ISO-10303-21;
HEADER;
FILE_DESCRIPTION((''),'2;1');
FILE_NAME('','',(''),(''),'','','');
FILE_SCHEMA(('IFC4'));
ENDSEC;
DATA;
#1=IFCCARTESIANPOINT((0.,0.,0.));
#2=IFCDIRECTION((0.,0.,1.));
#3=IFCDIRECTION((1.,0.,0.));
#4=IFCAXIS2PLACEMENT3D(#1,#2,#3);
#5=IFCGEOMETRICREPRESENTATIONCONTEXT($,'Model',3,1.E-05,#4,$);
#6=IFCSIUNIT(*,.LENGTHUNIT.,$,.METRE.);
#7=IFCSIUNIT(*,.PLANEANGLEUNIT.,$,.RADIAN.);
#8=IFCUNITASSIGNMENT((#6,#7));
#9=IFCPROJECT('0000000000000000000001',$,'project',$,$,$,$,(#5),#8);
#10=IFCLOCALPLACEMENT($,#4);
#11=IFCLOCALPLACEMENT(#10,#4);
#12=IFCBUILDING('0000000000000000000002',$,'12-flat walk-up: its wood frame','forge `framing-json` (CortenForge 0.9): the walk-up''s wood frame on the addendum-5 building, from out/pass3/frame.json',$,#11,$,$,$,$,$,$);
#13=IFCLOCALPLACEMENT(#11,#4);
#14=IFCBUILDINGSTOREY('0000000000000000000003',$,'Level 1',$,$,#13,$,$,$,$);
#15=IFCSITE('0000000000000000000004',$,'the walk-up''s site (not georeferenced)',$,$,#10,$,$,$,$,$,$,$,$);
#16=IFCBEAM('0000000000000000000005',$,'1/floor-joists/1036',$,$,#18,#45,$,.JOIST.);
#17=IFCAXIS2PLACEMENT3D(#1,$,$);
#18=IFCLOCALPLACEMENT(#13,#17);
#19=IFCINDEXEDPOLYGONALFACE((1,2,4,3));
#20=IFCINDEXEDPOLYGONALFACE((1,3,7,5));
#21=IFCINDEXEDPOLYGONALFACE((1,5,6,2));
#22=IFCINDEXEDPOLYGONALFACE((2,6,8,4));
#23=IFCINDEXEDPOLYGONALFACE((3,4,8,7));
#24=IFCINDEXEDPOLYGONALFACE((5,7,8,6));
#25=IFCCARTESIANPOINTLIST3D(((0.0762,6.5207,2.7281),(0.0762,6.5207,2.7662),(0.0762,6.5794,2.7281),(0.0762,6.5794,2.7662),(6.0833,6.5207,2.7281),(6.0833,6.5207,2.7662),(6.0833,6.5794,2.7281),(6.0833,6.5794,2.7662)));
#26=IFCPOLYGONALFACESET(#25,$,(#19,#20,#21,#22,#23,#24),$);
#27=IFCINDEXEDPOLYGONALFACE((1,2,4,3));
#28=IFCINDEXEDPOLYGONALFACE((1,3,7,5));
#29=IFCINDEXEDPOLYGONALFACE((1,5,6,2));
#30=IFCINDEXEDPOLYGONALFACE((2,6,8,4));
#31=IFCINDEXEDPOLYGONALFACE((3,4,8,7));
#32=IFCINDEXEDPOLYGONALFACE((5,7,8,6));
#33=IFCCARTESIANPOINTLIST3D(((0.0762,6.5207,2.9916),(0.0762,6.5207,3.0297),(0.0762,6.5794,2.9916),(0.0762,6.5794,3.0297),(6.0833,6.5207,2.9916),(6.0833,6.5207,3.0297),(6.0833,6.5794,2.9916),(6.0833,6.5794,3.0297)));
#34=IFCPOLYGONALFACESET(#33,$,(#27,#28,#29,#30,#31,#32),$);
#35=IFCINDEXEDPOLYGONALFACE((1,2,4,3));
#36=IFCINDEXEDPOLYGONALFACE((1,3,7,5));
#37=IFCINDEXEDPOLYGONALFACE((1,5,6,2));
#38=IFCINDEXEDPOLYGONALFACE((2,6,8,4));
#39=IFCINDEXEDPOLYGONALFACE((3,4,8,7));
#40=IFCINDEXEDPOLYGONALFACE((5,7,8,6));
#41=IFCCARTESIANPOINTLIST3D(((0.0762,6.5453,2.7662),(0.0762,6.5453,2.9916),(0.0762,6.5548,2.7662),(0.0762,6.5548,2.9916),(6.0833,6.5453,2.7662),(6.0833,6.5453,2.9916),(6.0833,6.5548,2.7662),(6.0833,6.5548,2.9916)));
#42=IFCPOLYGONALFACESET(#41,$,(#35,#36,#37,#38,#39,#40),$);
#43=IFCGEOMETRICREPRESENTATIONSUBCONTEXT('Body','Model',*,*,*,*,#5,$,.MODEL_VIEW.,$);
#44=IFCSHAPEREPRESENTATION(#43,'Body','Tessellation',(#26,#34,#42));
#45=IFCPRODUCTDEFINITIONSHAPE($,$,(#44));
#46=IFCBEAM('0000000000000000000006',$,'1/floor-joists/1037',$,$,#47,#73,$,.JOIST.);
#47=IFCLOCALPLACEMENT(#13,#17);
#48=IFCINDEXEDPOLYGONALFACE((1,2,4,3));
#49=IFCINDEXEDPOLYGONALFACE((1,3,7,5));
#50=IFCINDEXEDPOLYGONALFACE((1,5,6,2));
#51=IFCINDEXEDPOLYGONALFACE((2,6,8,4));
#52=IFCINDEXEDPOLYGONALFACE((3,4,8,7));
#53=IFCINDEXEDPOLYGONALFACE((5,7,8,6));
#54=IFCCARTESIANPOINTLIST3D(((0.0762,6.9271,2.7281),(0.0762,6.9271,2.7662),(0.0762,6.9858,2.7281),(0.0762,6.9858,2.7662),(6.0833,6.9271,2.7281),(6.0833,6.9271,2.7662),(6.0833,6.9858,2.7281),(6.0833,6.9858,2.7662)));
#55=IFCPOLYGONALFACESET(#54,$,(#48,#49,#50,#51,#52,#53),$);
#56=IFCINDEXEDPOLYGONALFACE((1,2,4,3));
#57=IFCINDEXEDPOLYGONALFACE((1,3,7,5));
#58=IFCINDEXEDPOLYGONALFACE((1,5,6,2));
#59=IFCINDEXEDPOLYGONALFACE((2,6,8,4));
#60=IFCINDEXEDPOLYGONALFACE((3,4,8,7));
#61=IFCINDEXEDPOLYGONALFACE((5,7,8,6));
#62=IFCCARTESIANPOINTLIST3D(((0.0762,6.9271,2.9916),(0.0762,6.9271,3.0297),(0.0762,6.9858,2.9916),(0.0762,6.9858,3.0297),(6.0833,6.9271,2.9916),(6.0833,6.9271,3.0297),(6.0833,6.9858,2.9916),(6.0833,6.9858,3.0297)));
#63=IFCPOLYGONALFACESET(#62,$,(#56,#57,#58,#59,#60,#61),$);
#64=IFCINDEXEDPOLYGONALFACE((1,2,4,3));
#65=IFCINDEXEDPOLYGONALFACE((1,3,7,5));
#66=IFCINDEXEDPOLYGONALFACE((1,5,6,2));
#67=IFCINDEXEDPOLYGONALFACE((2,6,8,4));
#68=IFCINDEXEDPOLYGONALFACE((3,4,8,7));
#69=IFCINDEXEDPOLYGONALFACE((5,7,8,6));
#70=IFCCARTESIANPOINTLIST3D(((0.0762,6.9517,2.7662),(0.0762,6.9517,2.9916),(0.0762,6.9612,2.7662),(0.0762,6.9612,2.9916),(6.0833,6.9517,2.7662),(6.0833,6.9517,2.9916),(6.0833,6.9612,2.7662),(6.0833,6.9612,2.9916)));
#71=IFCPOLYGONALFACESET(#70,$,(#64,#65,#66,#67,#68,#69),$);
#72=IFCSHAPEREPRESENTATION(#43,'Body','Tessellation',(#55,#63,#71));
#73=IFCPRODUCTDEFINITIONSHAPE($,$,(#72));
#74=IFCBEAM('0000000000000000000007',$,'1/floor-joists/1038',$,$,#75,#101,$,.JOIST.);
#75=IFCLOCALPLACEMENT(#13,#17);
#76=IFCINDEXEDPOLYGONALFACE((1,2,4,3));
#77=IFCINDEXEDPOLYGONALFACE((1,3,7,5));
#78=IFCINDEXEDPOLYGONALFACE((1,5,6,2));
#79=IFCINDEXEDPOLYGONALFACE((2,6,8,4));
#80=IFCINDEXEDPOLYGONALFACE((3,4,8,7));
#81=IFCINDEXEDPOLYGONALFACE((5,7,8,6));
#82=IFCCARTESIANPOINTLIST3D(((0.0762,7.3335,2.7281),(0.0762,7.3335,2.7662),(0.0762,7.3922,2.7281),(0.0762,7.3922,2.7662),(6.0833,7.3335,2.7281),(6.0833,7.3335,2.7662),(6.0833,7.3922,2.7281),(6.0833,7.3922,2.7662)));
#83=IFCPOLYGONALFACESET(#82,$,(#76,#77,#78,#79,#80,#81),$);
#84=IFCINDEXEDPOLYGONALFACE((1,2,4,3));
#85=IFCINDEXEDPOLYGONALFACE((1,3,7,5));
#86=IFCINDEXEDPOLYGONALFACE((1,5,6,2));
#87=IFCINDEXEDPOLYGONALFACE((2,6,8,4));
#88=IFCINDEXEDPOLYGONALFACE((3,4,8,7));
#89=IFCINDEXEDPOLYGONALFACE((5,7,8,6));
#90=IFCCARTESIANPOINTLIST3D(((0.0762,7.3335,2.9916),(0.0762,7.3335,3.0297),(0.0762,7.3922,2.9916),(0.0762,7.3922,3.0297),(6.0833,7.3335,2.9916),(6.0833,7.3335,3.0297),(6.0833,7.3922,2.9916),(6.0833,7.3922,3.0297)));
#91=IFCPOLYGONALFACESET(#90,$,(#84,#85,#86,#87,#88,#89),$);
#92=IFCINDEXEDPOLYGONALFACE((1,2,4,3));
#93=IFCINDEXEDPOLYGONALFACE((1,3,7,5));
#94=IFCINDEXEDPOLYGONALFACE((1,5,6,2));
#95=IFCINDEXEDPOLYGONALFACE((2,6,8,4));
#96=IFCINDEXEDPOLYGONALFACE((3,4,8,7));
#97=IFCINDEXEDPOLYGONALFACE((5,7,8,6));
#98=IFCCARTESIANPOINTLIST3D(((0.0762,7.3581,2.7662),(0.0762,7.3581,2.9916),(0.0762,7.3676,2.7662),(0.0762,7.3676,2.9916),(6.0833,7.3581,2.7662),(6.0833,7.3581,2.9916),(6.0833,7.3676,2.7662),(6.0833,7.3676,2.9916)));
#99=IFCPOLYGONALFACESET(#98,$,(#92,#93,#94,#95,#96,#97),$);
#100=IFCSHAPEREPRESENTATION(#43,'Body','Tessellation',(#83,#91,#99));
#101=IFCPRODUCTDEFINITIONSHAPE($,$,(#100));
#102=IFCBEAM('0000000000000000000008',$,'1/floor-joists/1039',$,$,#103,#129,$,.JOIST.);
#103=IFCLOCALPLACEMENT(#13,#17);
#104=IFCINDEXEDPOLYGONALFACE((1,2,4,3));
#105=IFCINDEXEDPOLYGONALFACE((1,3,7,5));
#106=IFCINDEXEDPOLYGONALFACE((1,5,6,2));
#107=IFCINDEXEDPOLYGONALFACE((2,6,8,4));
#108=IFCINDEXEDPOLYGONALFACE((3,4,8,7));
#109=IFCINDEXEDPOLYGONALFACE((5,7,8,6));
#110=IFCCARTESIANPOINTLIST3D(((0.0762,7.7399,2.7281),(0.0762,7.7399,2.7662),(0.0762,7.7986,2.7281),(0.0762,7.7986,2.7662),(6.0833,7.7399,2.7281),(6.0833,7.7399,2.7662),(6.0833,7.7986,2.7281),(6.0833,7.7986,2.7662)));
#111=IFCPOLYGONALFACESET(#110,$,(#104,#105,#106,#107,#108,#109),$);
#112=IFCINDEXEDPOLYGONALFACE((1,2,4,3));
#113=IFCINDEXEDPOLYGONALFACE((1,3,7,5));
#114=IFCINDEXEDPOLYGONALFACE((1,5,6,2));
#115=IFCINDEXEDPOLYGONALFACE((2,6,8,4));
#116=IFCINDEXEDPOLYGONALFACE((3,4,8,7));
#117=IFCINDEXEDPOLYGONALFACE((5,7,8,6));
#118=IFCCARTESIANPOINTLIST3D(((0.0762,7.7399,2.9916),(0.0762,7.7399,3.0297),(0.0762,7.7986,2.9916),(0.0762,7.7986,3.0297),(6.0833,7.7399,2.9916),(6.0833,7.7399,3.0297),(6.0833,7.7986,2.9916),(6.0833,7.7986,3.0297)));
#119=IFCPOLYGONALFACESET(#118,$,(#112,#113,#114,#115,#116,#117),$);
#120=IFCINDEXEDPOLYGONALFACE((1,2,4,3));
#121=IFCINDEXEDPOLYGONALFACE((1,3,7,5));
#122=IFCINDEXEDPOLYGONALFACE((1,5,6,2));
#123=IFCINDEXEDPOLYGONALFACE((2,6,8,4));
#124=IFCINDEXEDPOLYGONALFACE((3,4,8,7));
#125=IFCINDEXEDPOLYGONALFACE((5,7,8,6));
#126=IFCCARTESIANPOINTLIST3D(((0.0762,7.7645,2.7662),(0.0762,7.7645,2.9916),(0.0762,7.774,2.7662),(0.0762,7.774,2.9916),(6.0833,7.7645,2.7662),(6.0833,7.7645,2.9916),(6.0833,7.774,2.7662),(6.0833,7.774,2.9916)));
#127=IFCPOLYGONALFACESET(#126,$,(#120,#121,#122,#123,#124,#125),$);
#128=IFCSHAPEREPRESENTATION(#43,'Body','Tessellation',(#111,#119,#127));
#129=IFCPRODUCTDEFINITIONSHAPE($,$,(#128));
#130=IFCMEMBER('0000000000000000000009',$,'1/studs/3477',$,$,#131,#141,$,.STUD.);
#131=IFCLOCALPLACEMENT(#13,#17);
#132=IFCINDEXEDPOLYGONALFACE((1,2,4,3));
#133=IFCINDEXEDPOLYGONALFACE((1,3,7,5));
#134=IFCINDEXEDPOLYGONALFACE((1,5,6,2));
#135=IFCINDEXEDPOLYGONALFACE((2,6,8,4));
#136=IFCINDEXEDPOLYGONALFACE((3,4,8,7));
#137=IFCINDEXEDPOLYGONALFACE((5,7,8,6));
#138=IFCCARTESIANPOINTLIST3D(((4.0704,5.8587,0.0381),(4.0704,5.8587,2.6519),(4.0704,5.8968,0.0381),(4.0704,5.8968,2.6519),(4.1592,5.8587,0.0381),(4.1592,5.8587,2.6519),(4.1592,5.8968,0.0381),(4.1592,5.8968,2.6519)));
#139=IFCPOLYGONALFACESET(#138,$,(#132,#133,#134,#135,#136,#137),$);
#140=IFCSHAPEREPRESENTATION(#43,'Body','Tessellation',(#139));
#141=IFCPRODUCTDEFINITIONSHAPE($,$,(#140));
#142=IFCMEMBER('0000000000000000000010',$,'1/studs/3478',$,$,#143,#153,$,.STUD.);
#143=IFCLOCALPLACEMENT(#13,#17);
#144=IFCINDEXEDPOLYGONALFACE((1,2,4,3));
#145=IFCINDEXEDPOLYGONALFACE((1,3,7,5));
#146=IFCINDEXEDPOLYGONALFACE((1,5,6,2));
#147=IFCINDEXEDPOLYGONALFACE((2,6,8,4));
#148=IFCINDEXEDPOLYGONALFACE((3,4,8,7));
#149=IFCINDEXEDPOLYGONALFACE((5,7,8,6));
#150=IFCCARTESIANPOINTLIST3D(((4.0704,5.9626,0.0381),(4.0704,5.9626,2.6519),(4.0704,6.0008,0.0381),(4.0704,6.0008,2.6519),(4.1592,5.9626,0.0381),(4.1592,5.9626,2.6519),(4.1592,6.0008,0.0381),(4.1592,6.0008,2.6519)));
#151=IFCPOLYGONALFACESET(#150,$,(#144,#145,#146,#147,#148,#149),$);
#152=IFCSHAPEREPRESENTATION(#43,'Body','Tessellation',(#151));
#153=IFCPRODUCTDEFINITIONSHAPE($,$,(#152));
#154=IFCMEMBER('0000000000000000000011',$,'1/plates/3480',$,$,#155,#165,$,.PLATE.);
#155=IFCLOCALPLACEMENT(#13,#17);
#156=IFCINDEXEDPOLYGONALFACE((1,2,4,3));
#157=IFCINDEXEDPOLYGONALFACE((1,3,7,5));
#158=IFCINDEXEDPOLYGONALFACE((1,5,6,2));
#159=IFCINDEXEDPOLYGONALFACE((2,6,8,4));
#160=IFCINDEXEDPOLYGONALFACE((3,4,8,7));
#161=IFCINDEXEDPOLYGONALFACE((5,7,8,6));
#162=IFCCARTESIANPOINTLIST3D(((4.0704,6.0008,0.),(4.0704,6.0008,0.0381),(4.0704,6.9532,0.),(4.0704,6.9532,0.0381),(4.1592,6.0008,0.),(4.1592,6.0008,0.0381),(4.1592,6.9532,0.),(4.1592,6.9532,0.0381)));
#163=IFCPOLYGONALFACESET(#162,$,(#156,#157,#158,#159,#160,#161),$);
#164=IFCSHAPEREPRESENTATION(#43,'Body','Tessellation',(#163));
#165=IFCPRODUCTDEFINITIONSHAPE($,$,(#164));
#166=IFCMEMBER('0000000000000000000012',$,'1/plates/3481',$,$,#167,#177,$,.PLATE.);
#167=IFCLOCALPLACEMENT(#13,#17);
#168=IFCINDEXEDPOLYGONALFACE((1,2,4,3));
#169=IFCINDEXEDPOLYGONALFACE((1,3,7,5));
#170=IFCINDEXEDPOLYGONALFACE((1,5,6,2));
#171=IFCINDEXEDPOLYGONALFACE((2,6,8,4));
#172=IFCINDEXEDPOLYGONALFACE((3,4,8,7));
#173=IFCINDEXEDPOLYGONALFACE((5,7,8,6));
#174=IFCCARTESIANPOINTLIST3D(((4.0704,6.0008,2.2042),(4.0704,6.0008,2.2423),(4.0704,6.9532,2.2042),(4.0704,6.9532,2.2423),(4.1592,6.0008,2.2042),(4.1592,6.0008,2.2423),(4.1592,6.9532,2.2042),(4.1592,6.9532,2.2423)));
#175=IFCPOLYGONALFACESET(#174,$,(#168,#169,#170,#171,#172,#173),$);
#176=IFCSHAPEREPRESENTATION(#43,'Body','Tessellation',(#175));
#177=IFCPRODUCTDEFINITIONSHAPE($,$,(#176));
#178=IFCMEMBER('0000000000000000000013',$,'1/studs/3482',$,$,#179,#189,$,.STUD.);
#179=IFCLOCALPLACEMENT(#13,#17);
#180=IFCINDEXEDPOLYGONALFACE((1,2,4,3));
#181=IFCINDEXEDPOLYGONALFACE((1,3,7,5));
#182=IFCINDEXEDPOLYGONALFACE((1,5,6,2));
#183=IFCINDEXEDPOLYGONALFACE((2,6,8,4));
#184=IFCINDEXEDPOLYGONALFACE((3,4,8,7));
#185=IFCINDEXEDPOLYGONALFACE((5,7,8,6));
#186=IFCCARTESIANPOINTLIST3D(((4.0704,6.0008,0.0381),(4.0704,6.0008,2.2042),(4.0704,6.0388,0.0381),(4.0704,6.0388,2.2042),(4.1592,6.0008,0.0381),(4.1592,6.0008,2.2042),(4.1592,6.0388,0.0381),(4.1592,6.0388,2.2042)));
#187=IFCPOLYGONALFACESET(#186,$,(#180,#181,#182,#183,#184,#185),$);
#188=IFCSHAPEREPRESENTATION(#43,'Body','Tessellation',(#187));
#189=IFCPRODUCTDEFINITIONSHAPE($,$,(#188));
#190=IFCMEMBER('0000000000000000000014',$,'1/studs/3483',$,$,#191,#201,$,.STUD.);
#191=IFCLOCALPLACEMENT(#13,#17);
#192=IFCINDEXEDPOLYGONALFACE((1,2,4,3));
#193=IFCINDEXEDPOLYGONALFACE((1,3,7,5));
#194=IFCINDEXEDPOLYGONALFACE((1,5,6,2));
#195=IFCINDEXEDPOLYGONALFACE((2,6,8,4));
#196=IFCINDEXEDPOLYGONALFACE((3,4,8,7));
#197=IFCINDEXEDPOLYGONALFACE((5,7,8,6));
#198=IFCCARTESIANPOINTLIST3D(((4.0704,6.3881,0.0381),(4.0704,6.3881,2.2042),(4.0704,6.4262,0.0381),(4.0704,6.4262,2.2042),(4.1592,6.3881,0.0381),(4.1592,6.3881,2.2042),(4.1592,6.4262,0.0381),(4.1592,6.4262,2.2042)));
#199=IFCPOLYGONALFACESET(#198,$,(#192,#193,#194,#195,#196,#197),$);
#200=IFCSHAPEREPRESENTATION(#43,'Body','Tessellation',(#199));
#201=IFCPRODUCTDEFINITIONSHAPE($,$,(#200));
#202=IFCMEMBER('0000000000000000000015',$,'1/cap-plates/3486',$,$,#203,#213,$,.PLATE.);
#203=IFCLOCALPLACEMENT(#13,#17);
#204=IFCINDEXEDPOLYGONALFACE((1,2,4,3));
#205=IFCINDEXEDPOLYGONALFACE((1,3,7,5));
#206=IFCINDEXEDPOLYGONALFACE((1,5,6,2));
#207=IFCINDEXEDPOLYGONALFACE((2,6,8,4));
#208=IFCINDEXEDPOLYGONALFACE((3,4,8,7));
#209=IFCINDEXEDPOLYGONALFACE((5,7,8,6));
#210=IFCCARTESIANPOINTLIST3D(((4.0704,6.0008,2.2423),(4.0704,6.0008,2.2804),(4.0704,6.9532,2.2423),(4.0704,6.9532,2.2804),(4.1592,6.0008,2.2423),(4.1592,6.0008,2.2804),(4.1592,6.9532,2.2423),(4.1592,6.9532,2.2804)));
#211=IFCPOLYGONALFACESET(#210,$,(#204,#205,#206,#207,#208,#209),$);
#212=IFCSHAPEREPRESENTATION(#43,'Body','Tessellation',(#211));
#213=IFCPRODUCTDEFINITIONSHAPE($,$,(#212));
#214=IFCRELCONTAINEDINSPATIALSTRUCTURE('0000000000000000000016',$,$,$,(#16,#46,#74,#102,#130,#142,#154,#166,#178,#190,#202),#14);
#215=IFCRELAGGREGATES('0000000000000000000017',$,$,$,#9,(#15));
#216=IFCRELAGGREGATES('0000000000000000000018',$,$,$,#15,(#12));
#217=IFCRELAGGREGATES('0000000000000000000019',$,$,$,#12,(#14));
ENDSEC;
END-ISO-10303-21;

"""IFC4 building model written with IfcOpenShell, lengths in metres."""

from ifc_helpers import new_model, si_unit, frame, frame_2d, origin, origin_with_axes, place, context, subcontext, project, spatial, rectangle, extrude, element, save


model = new_model("IFC4")

# Units and contexts
model_context = context("Model", 3, precision=1e-05, world=origin_with_axes())
body_context = subcontext(model_context, "Body", "Model", "MODEL_VIEW")
ifc_project = project(units=[si_unit("LENGTHUNIT", "METRE"), si_unit("PLANEANGLEUNIT", "RADIAN")], contexts=[model_context])

# Site, building, storey
site_placement = place(None, origin_with_axes())
site = spatial("IfcSite", under=ifc_project, at=site_placement, Name="the walk-up's site (not georeferenced)")
building_placement = place(site_placement, origin_with_axes())
building = spatial("IfcBuilding", under=site, at=building_placement, Name="12-flat walk-up: its wood frame", Description="forge `framing-json` (CortenForge 0.9): the walk-up's wood frame on the addendum-5 building, from out/pass3/frame.json")
storey_placement = place(building_placement, origin_with_axes())
storey = spatial("IfcBuildingStorey", under=building, at=storey_placement, Name="Level 1")

# Beams
beam_1_placement = place(storey_placement, frame((0.0762, 6.5207, 2.7281), z_axis=(0.0, 0.0, 1.0), x_axis=(1.0, 0.0, 0.0)))
element("IfcBeam", 1, at=beam_1_placement, inside=storey, Name="1/floor-joists/1036", PredefinedType="JOIST", context=body_context, shape_type="SweptSolid", body=[
    extrude(rectangle(XDim=6.0071, YDim=0.0587, at=frame_2d((3.0036, 0.0294))), origin(), (0.0, 0.0, 1.0), 0.0381),
    extrude(rectangle(XDim=6.0071, YDim=0.0587, at=frame_2d((3.0036, 0.0294))), frame((0.0, 0.0, 0.2635)), (0.0, 0.0, 1.0), 0.0381),
    extrude(rectangle(XDim=6.0071, YDim=0.0095, at=frame_2d((3.0036, 0.0048))), frame((0.0, 0.0246, 0.0381)), (0.0, 0.0, 1.0), 0.2254),
])
beam_2_placement = place(storey_placement, frame((0.0762, 6.9271, 2.7281), z_axis=(0.0, 0.0, 1.0), x_axis=(1.0, 0.0, 0.0)))
element("IfcBeam", 2, at=beam_2_placement, inside=storey, Name="1/floor-joists/1037", PredefinedType="JOIST", context=body_context, shape_type="SweptSolid", body=[
    extrude(rectangle(XDim=6.0071, YDim=0.0587, at=frame_2d((3.0036, 0.0294))), origin(), (0.0, 0.0, 1.0), 0.0381),
    extrude(rectangle(XDim=6.0071, YDim=0.0587, at=frame_2d((3.0036, 0.0294))), frame((0.0, 0.0, 0.2635)), (0.0, 0.0, 1.0), 0.0381),
    extrude(rectangle(XDim=6.0071, YDim=0.0095, at=frame_2d((3.0036, 0.0048))), frame((0.0, 0.0246, 0.0381)), (0.0, 0.0, 1.0), 0.2254),
])
for number, where, z_axis, x_axis, name in (
    (3, (0.0762, 7.3335, 2.7281), (0.0, 0.0, 1.0), (1.0, 0.0, 0.0), "1/floor-joists/1038"),
    (4, (0.0762, 7.7399, 2.7281), (0.0, 0.0, 1.0), (1.0, 0.0, 0.0), "1/floor-joists/1039"),
):
    element("IfcBeam", number, at=place(storey_placement, frame(where, z_axis=z_axis, x_axis=x_axis)), inside=storey, Name=name, PredefinedType="JOIST", context=body_context, shape_type="SweptSolid", body=[
        extrude(rectangle(XDim=6.0071, YDim=0.0587, at=frame_2d((3.0036, 0.0294))), origin(), (0.0, 0.0, 1.0), 0.0381),
        extrude(rectangle(XDim=6.0071, YDim=0.0587, at=frame_2d((3.0036, 0.0294))), frame((0.0, 0.0, 0.2635)), (0.0, 0.0, 1.0), 0.0381),
        extrude(rectangle(XDim=6.0071, YDim=0.0095, at=frame_2d((3.0036, 0.0048))), frame((0.0, 0.0246, 0.0381)), (0.0, 0.0, 1.0), 0.2254),
    ])

# Members
for number, where, z_axis, x_axis, name in (
    (5, (4.0704, 5.8587, 0.0381), (0.0, 0.0, 1.0), (1.0, 0.0, 0.0), "1/studs/3477"),
    (6, (4.0704, 5.9627, 0.0381), (0.0, 0.0, 1.0), (1.0, 0.0, 0.0), "1/studs/3478"),
):
    element("IfcMember", number, at=place(storey_placement, frame(where, z_axis=z_axis, x_axis=x_axis)), inside=storey, Name=name, PredefinedType="STUD", context=body_context, shape_type="SweptSolid", body=[
        extrude(rectangle(XDim=0.0889, YDim=0.0381, at=frame_2d((0.0444, 0.0191))), origin(), (0.0, 0.0, 1.0), 2.6138),
    ])
member_1_placement = place(storey_placement, frame((4.0704, 6.0008, 0.0), z_axis=(0.0, 0.0, 1.0), x_axis=(1.0, 0.0, 0.0)))
element("IfcMember", 7, at=member_1_placement, inside=storey, Name="1/plates/3480", PredefinedType="PLATE", context=body_context, shape_type="SweptSolid", body=[
    extrude(rectangle(XDim=0.0889, YDim=0.9525, at=frame_2d((0.0444, 0.4762))), origin(), (0.0, 0.0, 1.0), 0.0381),
])
member_2_placement = place(storey_placement, frame((4.0704, 6.0008, 2.2042), z_axis=(0.0, 0.0, 1.0), x_axis=(1.0, 0.0, 0.0)))
element("IfcMember", 8, at=member_2_placement, inside=storey, Name="1/plates/3481", PredefinedType="PLATE", context=body_context, shape_type="SweptSolid", body=[
    extrude(rectangle(XDim=0.0889, YDim=0.9525, at=frame_2d((0.0444, 0.4762))), origin(), (0.0, 0.0, 1.0), 0.0381),
])
for number, where, z_axis, x_axis, name in (
    (9, (4.0704, 6.0008, 0.0381), (0.0, 0.0, 1.0), (1.0, 0.0, 0.0), "1/studs/3482"),
    (10, (4.0704, 6.3881, 0.0381), (0.0, 0.0, 1.0), (1.0, 0.0, 0.0), "1/studs/3483"),
):
    element("IfcMember", number, at=place(storey_placement, frame(where, z_axis=z_axis, x_axis=x_axis)), inside=storey, Name=name, PredefinedType="STUD", context=body_context, shape_type="SweptSolid", body=[
        extrude(rectangle(XDim=0.0889, YDim=0.0381, at=frame_2d((0.0444, 0.0191))), origin(), (0.0, 0.0, 1.0), 2.1661),
    ])
member_3_placement = place(storey_placement, frame((4.0704, 6.0008, 2.2423), z_axis=(0.0, 0.0, 1.0), x_axis=(1.0, 0.0, 0.0)))
element("IfcMember", 11, at=member_3_placement, inside=storey, Name="1/cap-plates/3486", PredefinedType="PLATE", context=body_context, shape_type="SweptSolid", body=[
    extrude(rectangle(XDim=0.0889, YDim=0.9525, at=frame_2d((0.0444, 0.4762))), origin(), (0.0, 0.0, 1.0), 0.0381),
])

save(model, "model.ifc")
